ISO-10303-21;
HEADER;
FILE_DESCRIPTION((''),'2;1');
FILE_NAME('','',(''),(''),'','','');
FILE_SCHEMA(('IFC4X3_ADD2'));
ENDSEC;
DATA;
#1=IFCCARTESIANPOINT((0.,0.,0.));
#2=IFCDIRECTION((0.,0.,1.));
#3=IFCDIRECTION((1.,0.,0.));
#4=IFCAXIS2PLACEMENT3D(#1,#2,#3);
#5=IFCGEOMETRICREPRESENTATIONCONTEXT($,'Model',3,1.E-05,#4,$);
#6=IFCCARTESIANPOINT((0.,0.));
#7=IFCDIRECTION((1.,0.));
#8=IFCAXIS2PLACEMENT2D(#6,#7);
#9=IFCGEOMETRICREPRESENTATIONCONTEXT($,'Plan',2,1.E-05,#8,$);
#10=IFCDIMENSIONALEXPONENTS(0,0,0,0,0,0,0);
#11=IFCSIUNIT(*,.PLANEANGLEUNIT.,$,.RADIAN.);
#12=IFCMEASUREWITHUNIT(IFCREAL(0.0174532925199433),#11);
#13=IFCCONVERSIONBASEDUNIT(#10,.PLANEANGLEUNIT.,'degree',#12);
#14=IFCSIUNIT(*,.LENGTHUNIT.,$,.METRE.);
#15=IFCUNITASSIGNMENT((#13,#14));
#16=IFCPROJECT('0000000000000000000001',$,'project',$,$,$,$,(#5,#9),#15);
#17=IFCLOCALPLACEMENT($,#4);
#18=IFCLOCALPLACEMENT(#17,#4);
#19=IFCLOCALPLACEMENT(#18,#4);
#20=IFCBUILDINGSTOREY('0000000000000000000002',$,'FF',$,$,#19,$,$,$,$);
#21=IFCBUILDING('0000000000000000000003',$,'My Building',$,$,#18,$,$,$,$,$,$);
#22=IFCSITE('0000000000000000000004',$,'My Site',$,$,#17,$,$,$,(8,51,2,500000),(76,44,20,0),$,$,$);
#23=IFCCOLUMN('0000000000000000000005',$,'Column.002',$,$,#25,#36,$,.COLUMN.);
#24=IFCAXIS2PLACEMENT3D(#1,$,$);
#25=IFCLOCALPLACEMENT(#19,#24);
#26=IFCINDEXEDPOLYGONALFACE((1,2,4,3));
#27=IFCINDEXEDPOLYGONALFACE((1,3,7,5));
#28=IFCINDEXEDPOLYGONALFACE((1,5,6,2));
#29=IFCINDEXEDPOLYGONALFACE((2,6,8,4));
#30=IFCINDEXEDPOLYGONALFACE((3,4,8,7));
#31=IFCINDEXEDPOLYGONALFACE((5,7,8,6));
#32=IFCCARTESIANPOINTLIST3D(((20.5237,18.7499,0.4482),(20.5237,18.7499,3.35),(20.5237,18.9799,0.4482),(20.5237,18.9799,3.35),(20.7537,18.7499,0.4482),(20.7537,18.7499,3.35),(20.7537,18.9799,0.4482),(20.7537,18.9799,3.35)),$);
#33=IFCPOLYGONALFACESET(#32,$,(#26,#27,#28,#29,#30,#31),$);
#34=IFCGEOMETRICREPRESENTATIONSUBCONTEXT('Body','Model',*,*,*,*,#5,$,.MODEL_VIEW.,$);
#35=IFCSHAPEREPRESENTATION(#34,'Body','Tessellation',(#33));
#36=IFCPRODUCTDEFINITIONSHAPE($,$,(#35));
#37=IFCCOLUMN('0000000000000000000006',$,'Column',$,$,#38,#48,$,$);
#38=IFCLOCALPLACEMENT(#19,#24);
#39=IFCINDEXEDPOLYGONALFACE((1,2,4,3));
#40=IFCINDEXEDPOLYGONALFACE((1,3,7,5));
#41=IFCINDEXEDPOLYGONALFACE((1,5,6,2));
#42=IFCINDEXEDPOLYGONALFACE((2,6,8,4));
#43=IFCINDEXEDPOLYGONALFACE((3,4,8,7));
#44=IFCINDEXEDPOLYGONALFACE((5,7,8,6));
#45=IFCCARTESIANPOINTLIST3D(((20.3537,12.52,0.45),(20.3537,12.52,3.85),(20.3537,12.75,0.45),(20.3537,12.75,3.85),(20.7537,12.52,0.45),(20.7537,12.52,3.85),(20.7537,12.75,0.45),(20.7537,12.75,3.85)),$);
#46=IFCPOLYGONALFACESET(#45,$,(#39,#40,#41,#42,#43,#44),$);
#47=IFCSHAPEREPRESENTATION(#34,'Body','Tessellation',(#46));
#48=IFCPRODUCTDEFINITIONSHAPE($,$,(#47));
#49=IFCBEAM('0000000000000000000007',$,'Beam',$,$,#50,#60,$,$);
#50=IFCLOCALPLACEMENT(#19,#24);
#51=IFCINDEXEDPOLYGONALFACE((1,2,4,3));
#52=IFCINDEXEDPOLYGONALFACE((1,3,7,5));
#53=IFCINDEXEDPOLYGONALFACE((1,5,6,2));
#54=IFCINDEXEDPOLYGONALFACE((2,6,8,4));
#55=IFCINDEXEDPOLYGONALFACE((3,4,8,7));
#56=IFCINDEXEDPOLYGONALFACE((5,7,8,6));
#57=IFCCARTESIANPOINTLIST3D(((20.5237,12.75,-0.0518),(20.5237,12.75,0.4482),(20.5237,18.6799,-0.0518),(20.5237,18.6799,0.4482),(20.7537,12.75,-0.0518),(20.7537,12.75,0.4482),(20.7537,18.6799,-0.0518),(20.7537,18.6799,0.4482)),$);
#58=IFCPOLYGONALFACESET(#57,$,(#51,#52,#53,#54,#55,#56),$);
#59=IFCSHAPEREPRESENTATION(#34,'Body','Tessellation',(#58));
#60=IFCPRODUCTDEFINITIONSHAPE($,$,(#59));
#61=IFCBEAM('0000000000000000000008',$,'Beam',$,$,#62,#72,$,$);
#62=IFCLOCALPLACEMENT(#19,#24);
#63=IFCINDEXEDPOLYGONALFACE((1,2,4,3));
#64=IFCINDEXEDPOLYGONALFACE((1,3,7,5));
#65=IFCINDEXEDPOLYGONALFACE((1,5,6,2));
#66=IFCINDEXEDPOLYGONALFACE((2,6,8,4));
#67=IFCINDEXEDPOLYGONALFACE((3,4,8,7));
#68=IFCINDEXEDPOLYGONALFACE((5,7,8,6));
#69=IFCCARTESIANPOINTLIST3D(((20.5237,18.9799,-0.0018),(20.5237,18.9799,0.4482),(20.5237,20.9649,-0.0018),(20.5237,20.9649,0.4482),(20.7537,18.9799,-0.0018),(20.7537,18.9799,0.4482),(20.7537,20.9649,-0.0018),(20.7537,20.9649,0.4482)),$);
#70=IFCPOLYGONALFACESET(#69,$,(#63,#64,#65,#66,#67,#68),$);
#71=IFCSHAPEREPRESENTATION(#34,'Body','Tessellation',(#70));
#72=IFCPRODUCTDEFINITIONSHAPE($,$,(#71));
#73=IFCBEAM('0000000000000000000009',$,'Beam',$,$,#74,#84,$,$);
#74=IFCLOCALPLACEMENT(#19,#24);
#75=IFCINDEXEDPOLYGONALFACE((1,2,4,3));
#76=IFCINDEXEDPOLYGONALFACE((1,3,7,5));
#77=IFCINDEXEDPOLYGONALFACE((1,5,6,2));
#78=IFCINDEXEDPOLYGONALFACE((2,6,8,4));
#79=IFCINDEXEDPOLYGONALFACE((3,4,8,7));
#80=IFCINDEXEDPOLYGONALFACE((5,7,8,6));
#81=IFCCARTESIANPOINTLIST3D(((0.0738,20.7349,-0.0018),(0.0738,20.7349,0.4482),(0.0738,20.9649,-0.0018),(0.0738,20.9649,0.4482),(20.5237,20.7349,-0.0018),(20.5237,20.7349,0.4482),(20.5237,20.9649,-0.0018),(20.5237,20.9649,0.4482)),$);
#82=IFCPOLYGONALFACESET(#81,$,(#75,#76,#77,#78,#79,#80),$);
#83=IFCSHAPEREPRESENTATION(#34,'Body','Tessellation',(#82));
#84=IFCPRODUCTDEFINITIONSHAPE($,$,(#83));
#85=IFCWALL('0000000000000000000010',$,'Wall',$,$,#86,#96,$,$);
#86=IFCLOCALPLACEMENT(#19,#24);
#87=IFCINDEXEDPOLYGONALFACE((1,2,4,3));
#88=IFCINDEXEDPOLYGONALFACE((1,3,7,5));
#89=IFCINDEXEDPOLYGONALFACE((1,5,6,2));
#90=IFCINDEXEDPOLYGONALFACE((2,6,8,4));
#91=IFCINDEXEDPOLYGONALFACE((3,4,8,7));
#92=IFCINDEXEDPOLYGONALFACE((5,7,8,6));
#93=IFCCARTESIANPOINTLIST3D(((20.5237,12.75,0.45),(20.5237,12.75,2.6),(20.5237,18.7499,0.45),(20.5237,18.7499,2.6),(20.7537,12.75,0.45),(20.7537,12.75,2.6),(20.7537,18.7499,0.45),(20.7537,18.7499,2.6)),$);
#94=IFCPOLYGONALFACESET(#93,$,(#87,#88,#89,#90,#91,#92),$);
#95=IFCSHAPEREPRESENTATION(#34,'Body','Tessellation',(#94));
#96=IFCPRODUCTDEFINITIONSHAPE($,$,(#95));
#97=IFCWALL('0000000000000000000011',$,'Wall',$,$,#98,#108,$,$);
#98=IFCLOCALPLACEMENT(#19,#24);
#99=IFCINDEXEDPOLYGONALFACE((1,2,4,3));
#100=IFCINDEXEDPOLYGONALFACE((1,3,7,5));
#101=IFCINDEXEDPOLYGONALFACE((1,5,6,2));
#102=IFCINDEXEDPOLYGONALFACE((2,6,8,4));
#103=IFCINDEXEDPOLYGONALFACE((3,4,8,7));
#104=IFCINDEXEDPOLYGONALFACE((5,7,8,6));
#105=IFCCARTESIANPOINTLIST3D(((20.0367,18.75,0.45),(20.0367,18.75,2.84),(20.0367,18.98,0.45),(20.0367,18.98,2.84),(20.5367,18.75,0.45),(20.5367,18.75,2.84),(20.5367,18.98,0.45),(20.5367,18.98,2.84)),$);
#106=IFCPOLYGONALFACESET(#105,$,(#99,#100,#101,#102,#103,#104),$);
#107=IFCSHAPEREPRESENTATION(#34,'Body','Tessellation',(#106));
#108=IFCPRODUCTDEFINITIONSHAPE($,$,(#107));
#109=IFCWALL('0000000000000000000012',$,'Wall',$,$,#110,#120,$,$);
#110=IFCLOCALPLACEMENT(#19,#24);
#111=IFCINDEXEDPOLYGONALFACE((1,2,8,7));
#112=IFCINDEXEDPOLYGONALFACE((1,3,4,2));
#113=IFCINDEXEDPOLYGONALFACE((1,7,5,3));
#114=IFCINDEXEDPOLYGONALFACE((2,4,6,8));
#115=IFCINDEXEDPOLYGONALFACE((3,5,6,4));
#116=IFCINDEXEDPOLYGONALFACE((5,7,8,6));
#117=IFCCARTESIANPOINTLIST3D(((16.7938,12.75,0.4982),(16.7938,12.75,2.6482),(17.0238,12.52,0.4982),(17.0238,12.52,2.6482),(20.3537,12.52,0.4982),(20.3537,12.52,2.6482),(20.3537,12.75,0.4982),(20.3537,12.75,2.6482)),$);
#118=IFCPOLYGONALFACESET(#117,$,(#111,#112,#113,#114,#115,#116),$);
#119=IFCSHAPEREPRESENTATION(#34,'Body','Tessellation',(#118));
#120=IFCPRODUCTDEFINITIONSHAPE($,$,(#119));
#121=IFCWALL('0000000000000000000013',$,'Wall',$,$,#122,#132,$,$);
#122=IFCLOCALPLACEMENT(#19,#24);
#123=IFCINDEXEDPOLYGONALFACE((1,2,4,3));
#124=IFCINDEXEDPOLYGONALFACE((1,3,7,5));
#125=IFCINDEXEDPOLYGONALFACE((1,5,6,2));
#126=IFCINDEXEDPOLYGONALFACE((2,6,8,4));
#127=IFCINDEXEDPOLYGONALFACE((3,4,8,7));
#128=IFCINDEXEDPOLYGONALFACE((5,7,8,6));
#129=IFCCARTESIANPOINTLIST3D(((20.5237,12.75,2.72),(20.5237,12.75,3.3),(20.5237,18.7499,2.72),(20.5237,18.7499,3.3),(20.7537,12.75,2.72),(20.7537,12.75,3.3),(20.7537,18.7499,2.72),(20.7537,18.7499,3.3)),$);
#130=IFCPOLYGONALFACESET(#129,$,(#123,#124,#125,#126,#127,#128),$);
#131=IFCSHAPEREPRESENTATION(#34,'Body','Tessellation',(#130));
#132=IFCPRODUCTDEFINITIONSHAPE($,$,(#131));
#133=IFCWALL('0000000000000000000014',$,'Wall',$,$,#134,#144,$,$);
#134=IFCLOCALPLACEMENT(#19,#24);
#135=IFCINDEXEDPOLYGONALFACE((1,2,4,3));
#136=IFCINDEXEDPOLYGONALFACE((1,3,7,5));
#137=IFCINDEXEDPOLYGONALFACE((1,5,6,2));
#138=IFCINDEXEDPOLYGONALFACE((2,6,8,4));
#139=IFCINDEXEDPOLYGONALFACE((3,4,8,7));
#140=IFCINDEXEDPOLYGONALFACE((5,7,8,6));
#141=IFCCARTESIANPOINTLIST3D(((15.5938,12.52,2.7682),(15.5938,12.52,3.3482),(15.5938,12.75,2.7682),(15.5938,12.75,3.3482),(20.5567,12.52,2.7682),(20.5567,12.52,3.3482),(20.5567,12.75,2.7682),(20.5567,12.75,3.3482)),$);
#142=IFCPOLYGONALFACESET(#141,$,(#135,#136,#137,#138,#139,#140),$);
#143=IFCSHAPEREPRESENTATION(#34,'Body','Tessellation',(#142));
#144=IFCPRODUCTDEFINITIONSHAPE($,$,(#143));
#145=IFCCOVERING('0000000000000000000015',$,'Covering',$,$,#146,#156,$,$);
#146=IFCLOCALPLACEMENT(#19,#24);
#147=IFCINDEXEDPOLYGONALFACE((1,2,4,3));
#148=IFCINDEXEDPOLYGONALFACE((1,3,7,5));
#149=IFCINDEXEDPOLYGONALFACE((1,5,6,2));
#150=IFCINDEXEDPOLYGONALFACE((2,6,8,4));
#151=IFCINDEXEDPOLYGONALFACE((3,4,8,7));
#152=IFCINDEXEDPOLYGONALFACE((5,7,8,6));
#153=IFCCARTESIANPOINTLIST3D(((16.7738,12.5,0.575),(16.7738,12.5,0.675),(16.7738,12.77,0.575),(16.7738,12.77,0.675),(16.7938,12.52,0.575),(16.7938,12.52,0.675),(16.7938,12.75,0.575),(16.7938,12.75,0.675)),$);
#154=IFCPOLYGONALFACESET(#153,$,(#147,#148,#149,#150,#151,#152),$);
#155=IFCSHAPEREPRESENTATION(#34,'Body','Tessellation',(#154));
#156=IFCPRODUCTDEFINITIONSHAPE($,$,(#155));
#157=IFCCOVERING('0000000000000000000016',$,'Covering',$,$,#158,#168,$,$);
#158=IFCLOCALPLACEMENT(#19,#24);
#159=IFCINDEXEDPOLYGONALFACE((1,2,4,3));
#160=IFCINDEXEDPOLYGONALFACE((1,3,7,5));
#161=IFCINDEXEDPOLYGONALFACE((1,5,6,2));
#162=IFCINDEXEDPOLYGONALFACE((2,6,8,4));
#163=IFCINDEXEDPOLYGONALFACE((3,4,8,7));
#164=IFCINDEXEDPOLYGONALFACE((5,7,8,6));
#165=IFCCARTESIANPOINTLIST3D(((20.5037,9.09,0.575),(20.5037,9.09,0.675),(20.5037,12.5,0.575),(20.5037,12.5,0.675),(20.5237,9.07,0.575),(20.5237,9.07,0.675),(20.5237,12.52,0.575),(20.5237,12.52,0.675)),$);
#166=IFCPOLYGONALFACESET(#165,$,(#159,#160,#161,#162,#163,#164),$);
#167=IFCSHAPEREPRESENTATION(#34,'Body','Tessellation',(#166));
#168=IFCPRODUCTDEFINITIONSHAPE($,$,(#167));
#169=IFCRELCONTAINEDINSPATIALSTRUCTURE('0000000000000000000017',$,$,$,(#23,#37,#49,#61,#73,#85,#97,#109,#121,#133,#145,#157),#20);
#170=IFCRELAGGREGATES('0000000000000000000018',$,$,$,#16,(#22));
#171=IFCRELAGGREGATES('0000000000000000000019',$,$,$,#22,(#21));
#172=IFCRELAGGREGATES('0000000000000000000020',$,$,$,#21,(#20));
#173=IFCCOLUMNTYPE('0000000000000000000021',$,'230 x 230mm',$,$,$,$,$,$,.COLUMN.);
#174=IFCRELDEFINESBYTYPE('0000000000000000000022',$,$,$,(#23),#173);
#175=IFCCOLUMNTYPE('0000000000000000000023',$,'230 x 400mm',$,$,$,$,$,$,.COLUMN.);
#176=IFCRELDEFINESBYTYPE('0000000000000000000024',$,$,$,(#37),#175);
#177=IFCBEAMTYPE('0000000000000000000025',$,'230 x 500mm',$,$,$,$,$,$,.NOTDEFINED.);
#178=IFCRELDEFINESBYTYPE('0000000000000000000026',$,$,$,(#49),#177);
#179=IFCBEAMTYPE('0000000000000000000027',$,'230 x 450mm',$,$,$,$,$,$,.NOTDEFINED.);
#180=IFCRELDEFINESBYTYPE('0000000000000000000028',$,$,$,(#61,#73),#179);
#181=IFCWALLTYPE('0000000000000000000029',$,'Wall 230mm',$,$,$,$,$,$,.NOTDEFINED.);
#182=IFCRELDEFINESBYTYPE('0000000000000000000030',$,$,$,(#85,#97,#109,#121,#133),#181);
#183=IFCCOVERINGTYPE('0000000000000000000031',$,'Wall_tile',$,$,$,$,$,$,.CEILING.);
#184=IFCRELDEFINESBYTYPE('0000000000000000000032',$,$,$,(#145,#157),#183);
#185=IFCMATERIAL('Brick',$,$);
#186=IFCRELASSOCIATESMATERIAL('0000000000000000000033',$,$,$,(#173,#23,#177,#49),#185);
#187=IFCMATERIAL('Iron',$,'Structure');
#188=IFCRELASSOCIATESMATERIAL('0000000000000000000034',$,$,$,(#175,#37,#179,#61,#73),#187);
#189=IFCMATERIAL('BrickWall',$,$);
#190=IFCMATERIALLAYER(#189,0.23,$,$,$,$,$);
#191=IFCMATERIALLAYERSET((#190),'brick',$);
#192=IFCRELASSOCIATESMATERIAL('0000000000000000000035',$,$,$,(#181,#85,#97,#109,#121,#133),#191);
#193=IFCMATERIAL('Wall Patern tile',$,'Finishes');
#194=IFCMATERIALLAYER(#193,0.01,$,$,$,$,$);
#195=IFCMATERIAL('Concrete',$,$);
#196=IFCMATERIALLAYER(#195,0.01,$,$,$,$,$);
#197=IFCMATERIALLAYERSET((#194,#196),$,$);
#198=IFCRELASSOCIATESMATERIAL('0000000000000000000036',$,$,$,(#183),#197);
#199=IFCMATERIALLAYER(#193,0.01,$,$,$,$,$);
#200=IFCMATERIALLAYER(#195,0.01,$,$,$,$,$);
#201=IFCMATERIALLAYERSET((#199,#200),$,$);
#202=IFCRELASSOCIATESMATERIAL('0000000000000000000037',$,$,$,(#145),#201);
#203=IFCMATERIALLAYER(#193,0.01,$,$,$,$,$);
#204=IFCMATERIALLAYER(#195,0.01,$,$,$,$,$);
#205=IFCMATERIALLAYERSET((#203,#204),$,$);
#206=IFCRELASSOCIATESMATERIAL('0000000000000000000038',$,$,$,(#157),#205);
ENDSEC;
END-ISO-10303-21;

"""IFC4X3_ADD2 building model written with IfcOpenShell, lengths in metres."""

from ifc_helpers import new_model, entity, si_unit, converted_unit, frame, origin_with_axes, origin_2d_with_axis, place, context, subcontext, project, spatial, line, indexed_curve, rectangle, outline, extrude, material, layer, layer_set, layer_usage, material_profile, profile_set, profile_usage, type_object, element, save


model = new_model("IFC4X3_ADD2")

# Units and contexts
model_context = context("Model", 3, precision=1e-05, world=origin_with_axes())
plan_context = context("Plan", 2, precision=1e-05, world=origin_2d_with_axis())
body_context_1 = subcontext(model_context, "Body", "Model", "MODEL_VIEW")
ifc_project = project(units=[converted_unit("PLANEANGLEUNIT", "degree", entity("IfcReal", 0.0174532925199433), si_unit("PLANEANGLEUNIT", "RADIAN"), dimensions=[0, 0, 0, 0, 0, 0, 0]), si_unit("LENGTHUNIT", "METRE")], contexts=[model_context, plan_context])

# Site, building, storey
site_placement = place(None, origin_with_axes())
site = spatial("IfcSite", under=ifc_project, at=site_placement, Name="My Site", RefLatitude=(8, 51, 2, 500000), RefLongitude=(76, 44, 20, 0))
building_placement = place(site_placement, origin_with_axes())
building = spatial("IfcBuilding", under=site, at=building_placement, Name="My Building")
storey_placement = place(building_placement, origin_with_axes())
storey = spatial("IfcBuildingStorey", under=building, at=storey_placement, Name="FF")

# Columns
ifc_material_1 = material(Name="Brick")
ifc_material_profile_1 = material_profile(ifc_material_1, outline(indexed_curve([(-0.115, 0.115), (0.115, 0.115), (0.115, -0.115), (-0.115, -0.115), (-0.115, 0.115)])))
ifc_profile_set_1 = profile_set([ifc_material_profile_1])
ifc_profile_usage_1 = profile_usage(ifc_profile_set_1)
column_type_1 = type_object("IfcColumnType", Name="230 x 230mm", PredefinedType="COLUMN", material=ifc_profile_set_1)
column_1_placement = place(storey_placement, frame((20.6387, 18.8649, 0.4482), z_axis=(0.0, 0.0, 1.0), x_axis=(1.0, 0.0, 0.0)))
element("IfcColumn", 1, at=column_1_placement, inside=storey, type_object=column_type_1, material=ifc_profile_usage_1, Name="Column.002", PredefinedType="COLUMN", context=body_context_1, shape_type="SweptSolid", body=[
    extrude(outline(indexed_curve([(-0.115, 0.115), (0.115, 0.115), (0.115, -0.115), (-0.115, -0.115), (-0.115, 0.115)])), origin_with_axes(), (0.0, 0.0, 1.0), 2.9018),
])
ifc_material_2 = material(Name="Iron", Category="Structure")
ifc_material_profile_2 = material_profile(ifc_material_2, outline(indexed_curve([(-0.115, 0.2), (0.115, 0.2), (0.115, -0.2), (-0.115, -0.2), (-0.115, 0.2)])))
ifc_profile_set_2 = profile_set([ifc_material_profile_2])
ifc_profile_usage_2 = profile_usage(ifc_profile_set_2)
column_type_2 = type_object("IfcColumnType", Name="230 x 400mm", PredefinedType="COLUMN", material=ifc_profile_set_2)
column_2_placement = place(storey_placement, frame((20.5537, 12.635, 0.45), z_axis=(0.0, 0.0, 1.0), x_axis=(0.0, 1.0, 0.0)))
element("IfcColumn", 2, at=column_2_placement, inside=storey, type_object=column_type_2, material=ifc_profile_usage_2, Name="Column", context=body_context_1, shape_type="SweptSolid", body=[
    extrude(outline(indexed_curve([(-0.115, 0.2), (0.115, 0.2), (0.115, -0.2), (-0.115, -0.2), (-0.115, 0.2)])), origin_with_axes(), (0.0, 0.0, 1.0), 3.4),
])

# Beams
ifc_material_profile_3 = material_profile(ifc_material_1, rectangle(XDim=0.23, YDim=0.5))
ifc_profile_set_3 = profile_set([ifc_material_profile_3], Name="rcc")
ifc_profile_usage_3 = profile_usage(ifc_profile_set_3)
beam_type_1 = type_object("IfcBeamType", Name="230 x 500mm", PredefinedType="NOTDEFINED", material=ifc_profile_set_3)
beam_1_placement = place(storey_placement, frame((20.6387, 12.75, 0.1982), z_axis=(0.0, 1.0, 0.0), x_axis=(-1.0, 0.0, 0.0)))
element("IfcBeam", 3, at=beam_1_placement, inside=storey, type_object=beam_type_1, material=ifc_profile_usage_3, Name="Beam", context=body_context_1, shape_type="SweptSolid", body=[
    extrude(rectangle(XDim=0.23, YDim=0.5), origin_with_axes(), (0.0, 0.0, 1.0), 5.9299),
])
ifc_material_profile_4 = material_profile(ifc_material_2, rectangle(XDim=0.23, YDim=0.45))
ifc_profile_set_4 = profile_set([ifc_material_profile_4], Name="blank")
ifc_profile_usage_4 = profile_usage(ifc_profile_set_4)
beam_type_2 = type_object("IfcBeamType", Name="230 x 450mm", PredefinedType="NOTDEFINED", material=ifc_profile_set_4)
beam_2_placement = place(storey_placement, frame((20.6387, 18.9799, 0.2232), z_axis=(0.0, 1.0, 0.0), x_axis=(-1.0, 0.0, 0.0)))
element("IfcBeam", 4, at=beam_2_placement, inside=storey, type_object=beam_type_2, material=ifc_profile_usage_4, Name="Beam", context=body_context_1, shape_type="SweptSolid", body=[
    extrude(rectangle(XDim=0.23, YDim=0.45), origin_with_axes(), (0.0, 0.0, 1.0), 1.985),
])
ifc_profile_usage_5 = profile_usage(ifc_profile_set_4)
beam_3_placement = place(storey_placement, frame((20.5237, 20.8499, 0.2232), z_axis=(-1.0, 0.0, 0.0), x_axis=(0.0, -1.0, 0.0)))
element("IfcBeam", 5, at=beam_3_placement, inside=storey, type_object=beam_type_2, material=ifc_profile_usage_5, Name="Beam", context=body_context_1, shape_type="SweptSolid", body=[
    extrude(rectangle(XDim=0.23, YDim=0.45), origin_with_axes(), (0.0, 0.0, 1.0), 20.4499),
])

# Walls
ifc_material_3 = material(Name="BrickWall")
ifc_layer_1 = layer(ifc_material_3, 0.23)
ifc_layer_set_1 = layer_set([ifc_layer_1], Name="brick")
ifc_layer_usage_1 = layer_usage(ifc_layer_set_1, "AXIS2", "POSITIVE", 0.0)
wall_type = type_object("IfcWallType", Name="Wall 230mm", PredefinedType="NOTDEFINED", material=ifc_layer_set_1)
wall_1_placement = place(storey_placement, frame((20.7537, 12.75, 0.45), z_axis=(0.0, 0.0, 1.0), x_axis=(0.0, 1.0, 0.0)))
element("IfcWall", 6, at=wall_1_placement, inside=storey, type_object=wall_type, material=ifc_layer_usage_1, Name="Wall", context=body_context_1, shape_type="SweptSolid", body=[
    extrude(outline(indexed_curve([(0.0, 0.0), (0.0, 0.23), (5.9999, 0.23), (5.9999, 0.0), (0.0, 0.0)], self_intersect=False)), origin_with_axes(), (0.0, 0.0, 1.0), 2.15),
])
ifc_layer_usage_2 = layer_usage(ifc_layer_set_1, "AXIS2", "POSITIVE", 0.0)
wall_2_placement = place(storey_placement, frame((20.5367, 18.98, 0.45), z_axis=(0.0, 0.0, 1.0), x_axis=(-1.0, 0.0, 0.0)))
element("IfcWall", 7, at=wall_2_placement, inside=storey, type_object=wall_type, material=ifc_layer_usage_2, Name="Wall", context=body_context_1, shape_type="SweptSolid", body=[
    extrude(outline(indexed_curve([(0.0, 0.0), (0.0, 0.23), (0.5, 0.23), (0.5, 0.0)], segments=[line(1, 2, 3, 4, 1)])), origin_with_axes(), (0.0, 0.0, 1.0), 2.39),
])
ifc_layer_usage_3 = layer_usage(ifc_layer_set_1, "AXIS2", "POSITIVE", 0.0)
wall_3_placement = place(storey_placement, frame((20.3537, 12.75, 0.4982), z_axis=(0.0, 0.0, 1.0), x_axis=(-1.0, 0.0, 0.0)))
element("IfcWall", 8, at=wall_3_placement, inside=storey, type_object=wall_type, material=ifc_layer_usage_3, Name="Wall", context=body_context_1, shape_type="SweptSolid", body=[
    extrude(outline(indexed_curve([(0.0, 0.0), (0.0, 0.23), (3.3299, 0.23), (3.5599, 0.0)], segments=[line(1, 2, 3, 4, 1)])), origin_with_axes(), (0.0, 0.0, 1.0), 2.15),
])
ifc_layer_usage_4 = layer_usage(ifc_layer_set_1, "AXIS2", "POSITIVE", 0.0)
wall_4_placement = place(storey_placement, frame((20.7537, 12.75, 2.72), z_axis=(0.0, 0.0, 1.0), x_axis=(0.0, 1.0, 0.0)))
element("IfcWall", 9, at=wall_4_placement, inside=storey, type_object=wall_type, material=ifc_layer_usage_4, Name="Wall", context=body_context_1, shape_type="SweptSolid", body=[
    extrude(outline(indexed_curve([(0.0, 0.0), (0.0, 0.23), (5.9999, 0.23), (5.9999, 0.0), (0.0, 0.0)], self_intersect=False)), origin_with_axes(), (0.0, 0.0, 1.0), 0.58),
])
ifc_layer_usage_5 = layer_usage(ifc_layer_set_1, "AXIS2", "POSITIVE", 0.0)
wall_5_placement = place(storey_placement, frame((20.5567, 12.75, 2.7682), z_axis=(0.0, 0.0, 1.0), x_axis=(-1.0, 0.0, 0.0)))
element("IfcWall", 10, at=wall_5_placement, inside=storey, type_object=wall_type, material=ifc_layer_usage_5, Name="Wall", context=body_context_1, shape_type="SweptSolid", body=[
    extrude(outline(indexed_curve([(0.0, 0.0), (0.0, 0.23), (4.9629, 0.23), (4.9629, 0.0)], segments=[line(1, 2, 3, 4, 1)])), origin_with_axes(), (0.0, 0.0, 1.0), 0.58),
])

# Coverings
ifc_material_4 = material(Name="Wall Patern tile", Category="Finishes")
ifc_layer_2 = layer(ifc_material_4, 0.01)
ifc_material_5 = material(Name="Concrete")
ifc_layer_3 = layer(ifc_material_5, 0.01)
ifc_layer_set_2 = layer_set([ifc_layer_2, ifc_layer_3])
ifc_layer_usage_6 = layer_usage(ifc_layer_set_2, "AXIS2", "NEGATIVE", 0.0)
ifc_layer_4 = layer(ifc_material_4, 0.01)
ifc_layer_5 = layer(ifc_material_5, 0.01)
ifc_layer_set_3 = layer_set([ifc_layer_4, ifc_layer_5])
covering_type = type_object("IfcCoveringType", Name="Wall_tile", PredefinedType="CEILING", material=ifc_layer_set_3)
covering_1_placement = place(storey_placement, frame((16.7738, 12.52, 0.575), z_axis=(0.0, 0.0, 1.0), x_axis=(0.0, 1.0, 0.0)))
element("IfcCovering", 11, at=covering_1_placement, inside=storey, type_object=covering_type, material=ifc_layer_usage_6, Name="Covering", context=body_context_1, shape_type="SweptSolid", body=[
    extrude(outline(indexed_curve([(0.0, -0.02), (-0.02, 0.0), (0.25, 0.0), (0.23, -0.02)], segments=[line(1, 2, 3, 4, 1)])), origin_with_axes(), (0.0, 0.0, 1.0), 0.1),
])
ifc_layer_6 = layer(ifc_material_4, 0.01)
ifc_layer_7 = layer(ifc_material_5, 0.01)
ifc_layer_set_4 = layer_set([ifc_layer_6, ifc_layer_7])
ifc_layer_usage_7 = layer_usage(ifc_layer_set_4, "AXIS2", "POSITIVE", 0.0)
covering_2_placement = place(storey_placement, frame((20.5037, 12.5, 0.575), z_axis=(0.0, 0.0, 1.0), x_axis=(0.0, -1.0, 0.0)))
element("IfcCovering", 12, at=covering_2_placement, inside=storey, type_object=covering_type, material=ifc_layer_usage_7, Name="Covering", context=body_context_1, shape_type="SweptSolid", body=[
    extrude(outline(indexed_curve([(0.0, 0.0), (-0.02, 0.02), (3.43, 0.02), (3.41, 0.0)], segments=[line(1, 2, 3, 4, 1)])), origin_with_axes(), (0.0, 0.0, 1.0), 0.1),
])

save(model, "model.ifc")
